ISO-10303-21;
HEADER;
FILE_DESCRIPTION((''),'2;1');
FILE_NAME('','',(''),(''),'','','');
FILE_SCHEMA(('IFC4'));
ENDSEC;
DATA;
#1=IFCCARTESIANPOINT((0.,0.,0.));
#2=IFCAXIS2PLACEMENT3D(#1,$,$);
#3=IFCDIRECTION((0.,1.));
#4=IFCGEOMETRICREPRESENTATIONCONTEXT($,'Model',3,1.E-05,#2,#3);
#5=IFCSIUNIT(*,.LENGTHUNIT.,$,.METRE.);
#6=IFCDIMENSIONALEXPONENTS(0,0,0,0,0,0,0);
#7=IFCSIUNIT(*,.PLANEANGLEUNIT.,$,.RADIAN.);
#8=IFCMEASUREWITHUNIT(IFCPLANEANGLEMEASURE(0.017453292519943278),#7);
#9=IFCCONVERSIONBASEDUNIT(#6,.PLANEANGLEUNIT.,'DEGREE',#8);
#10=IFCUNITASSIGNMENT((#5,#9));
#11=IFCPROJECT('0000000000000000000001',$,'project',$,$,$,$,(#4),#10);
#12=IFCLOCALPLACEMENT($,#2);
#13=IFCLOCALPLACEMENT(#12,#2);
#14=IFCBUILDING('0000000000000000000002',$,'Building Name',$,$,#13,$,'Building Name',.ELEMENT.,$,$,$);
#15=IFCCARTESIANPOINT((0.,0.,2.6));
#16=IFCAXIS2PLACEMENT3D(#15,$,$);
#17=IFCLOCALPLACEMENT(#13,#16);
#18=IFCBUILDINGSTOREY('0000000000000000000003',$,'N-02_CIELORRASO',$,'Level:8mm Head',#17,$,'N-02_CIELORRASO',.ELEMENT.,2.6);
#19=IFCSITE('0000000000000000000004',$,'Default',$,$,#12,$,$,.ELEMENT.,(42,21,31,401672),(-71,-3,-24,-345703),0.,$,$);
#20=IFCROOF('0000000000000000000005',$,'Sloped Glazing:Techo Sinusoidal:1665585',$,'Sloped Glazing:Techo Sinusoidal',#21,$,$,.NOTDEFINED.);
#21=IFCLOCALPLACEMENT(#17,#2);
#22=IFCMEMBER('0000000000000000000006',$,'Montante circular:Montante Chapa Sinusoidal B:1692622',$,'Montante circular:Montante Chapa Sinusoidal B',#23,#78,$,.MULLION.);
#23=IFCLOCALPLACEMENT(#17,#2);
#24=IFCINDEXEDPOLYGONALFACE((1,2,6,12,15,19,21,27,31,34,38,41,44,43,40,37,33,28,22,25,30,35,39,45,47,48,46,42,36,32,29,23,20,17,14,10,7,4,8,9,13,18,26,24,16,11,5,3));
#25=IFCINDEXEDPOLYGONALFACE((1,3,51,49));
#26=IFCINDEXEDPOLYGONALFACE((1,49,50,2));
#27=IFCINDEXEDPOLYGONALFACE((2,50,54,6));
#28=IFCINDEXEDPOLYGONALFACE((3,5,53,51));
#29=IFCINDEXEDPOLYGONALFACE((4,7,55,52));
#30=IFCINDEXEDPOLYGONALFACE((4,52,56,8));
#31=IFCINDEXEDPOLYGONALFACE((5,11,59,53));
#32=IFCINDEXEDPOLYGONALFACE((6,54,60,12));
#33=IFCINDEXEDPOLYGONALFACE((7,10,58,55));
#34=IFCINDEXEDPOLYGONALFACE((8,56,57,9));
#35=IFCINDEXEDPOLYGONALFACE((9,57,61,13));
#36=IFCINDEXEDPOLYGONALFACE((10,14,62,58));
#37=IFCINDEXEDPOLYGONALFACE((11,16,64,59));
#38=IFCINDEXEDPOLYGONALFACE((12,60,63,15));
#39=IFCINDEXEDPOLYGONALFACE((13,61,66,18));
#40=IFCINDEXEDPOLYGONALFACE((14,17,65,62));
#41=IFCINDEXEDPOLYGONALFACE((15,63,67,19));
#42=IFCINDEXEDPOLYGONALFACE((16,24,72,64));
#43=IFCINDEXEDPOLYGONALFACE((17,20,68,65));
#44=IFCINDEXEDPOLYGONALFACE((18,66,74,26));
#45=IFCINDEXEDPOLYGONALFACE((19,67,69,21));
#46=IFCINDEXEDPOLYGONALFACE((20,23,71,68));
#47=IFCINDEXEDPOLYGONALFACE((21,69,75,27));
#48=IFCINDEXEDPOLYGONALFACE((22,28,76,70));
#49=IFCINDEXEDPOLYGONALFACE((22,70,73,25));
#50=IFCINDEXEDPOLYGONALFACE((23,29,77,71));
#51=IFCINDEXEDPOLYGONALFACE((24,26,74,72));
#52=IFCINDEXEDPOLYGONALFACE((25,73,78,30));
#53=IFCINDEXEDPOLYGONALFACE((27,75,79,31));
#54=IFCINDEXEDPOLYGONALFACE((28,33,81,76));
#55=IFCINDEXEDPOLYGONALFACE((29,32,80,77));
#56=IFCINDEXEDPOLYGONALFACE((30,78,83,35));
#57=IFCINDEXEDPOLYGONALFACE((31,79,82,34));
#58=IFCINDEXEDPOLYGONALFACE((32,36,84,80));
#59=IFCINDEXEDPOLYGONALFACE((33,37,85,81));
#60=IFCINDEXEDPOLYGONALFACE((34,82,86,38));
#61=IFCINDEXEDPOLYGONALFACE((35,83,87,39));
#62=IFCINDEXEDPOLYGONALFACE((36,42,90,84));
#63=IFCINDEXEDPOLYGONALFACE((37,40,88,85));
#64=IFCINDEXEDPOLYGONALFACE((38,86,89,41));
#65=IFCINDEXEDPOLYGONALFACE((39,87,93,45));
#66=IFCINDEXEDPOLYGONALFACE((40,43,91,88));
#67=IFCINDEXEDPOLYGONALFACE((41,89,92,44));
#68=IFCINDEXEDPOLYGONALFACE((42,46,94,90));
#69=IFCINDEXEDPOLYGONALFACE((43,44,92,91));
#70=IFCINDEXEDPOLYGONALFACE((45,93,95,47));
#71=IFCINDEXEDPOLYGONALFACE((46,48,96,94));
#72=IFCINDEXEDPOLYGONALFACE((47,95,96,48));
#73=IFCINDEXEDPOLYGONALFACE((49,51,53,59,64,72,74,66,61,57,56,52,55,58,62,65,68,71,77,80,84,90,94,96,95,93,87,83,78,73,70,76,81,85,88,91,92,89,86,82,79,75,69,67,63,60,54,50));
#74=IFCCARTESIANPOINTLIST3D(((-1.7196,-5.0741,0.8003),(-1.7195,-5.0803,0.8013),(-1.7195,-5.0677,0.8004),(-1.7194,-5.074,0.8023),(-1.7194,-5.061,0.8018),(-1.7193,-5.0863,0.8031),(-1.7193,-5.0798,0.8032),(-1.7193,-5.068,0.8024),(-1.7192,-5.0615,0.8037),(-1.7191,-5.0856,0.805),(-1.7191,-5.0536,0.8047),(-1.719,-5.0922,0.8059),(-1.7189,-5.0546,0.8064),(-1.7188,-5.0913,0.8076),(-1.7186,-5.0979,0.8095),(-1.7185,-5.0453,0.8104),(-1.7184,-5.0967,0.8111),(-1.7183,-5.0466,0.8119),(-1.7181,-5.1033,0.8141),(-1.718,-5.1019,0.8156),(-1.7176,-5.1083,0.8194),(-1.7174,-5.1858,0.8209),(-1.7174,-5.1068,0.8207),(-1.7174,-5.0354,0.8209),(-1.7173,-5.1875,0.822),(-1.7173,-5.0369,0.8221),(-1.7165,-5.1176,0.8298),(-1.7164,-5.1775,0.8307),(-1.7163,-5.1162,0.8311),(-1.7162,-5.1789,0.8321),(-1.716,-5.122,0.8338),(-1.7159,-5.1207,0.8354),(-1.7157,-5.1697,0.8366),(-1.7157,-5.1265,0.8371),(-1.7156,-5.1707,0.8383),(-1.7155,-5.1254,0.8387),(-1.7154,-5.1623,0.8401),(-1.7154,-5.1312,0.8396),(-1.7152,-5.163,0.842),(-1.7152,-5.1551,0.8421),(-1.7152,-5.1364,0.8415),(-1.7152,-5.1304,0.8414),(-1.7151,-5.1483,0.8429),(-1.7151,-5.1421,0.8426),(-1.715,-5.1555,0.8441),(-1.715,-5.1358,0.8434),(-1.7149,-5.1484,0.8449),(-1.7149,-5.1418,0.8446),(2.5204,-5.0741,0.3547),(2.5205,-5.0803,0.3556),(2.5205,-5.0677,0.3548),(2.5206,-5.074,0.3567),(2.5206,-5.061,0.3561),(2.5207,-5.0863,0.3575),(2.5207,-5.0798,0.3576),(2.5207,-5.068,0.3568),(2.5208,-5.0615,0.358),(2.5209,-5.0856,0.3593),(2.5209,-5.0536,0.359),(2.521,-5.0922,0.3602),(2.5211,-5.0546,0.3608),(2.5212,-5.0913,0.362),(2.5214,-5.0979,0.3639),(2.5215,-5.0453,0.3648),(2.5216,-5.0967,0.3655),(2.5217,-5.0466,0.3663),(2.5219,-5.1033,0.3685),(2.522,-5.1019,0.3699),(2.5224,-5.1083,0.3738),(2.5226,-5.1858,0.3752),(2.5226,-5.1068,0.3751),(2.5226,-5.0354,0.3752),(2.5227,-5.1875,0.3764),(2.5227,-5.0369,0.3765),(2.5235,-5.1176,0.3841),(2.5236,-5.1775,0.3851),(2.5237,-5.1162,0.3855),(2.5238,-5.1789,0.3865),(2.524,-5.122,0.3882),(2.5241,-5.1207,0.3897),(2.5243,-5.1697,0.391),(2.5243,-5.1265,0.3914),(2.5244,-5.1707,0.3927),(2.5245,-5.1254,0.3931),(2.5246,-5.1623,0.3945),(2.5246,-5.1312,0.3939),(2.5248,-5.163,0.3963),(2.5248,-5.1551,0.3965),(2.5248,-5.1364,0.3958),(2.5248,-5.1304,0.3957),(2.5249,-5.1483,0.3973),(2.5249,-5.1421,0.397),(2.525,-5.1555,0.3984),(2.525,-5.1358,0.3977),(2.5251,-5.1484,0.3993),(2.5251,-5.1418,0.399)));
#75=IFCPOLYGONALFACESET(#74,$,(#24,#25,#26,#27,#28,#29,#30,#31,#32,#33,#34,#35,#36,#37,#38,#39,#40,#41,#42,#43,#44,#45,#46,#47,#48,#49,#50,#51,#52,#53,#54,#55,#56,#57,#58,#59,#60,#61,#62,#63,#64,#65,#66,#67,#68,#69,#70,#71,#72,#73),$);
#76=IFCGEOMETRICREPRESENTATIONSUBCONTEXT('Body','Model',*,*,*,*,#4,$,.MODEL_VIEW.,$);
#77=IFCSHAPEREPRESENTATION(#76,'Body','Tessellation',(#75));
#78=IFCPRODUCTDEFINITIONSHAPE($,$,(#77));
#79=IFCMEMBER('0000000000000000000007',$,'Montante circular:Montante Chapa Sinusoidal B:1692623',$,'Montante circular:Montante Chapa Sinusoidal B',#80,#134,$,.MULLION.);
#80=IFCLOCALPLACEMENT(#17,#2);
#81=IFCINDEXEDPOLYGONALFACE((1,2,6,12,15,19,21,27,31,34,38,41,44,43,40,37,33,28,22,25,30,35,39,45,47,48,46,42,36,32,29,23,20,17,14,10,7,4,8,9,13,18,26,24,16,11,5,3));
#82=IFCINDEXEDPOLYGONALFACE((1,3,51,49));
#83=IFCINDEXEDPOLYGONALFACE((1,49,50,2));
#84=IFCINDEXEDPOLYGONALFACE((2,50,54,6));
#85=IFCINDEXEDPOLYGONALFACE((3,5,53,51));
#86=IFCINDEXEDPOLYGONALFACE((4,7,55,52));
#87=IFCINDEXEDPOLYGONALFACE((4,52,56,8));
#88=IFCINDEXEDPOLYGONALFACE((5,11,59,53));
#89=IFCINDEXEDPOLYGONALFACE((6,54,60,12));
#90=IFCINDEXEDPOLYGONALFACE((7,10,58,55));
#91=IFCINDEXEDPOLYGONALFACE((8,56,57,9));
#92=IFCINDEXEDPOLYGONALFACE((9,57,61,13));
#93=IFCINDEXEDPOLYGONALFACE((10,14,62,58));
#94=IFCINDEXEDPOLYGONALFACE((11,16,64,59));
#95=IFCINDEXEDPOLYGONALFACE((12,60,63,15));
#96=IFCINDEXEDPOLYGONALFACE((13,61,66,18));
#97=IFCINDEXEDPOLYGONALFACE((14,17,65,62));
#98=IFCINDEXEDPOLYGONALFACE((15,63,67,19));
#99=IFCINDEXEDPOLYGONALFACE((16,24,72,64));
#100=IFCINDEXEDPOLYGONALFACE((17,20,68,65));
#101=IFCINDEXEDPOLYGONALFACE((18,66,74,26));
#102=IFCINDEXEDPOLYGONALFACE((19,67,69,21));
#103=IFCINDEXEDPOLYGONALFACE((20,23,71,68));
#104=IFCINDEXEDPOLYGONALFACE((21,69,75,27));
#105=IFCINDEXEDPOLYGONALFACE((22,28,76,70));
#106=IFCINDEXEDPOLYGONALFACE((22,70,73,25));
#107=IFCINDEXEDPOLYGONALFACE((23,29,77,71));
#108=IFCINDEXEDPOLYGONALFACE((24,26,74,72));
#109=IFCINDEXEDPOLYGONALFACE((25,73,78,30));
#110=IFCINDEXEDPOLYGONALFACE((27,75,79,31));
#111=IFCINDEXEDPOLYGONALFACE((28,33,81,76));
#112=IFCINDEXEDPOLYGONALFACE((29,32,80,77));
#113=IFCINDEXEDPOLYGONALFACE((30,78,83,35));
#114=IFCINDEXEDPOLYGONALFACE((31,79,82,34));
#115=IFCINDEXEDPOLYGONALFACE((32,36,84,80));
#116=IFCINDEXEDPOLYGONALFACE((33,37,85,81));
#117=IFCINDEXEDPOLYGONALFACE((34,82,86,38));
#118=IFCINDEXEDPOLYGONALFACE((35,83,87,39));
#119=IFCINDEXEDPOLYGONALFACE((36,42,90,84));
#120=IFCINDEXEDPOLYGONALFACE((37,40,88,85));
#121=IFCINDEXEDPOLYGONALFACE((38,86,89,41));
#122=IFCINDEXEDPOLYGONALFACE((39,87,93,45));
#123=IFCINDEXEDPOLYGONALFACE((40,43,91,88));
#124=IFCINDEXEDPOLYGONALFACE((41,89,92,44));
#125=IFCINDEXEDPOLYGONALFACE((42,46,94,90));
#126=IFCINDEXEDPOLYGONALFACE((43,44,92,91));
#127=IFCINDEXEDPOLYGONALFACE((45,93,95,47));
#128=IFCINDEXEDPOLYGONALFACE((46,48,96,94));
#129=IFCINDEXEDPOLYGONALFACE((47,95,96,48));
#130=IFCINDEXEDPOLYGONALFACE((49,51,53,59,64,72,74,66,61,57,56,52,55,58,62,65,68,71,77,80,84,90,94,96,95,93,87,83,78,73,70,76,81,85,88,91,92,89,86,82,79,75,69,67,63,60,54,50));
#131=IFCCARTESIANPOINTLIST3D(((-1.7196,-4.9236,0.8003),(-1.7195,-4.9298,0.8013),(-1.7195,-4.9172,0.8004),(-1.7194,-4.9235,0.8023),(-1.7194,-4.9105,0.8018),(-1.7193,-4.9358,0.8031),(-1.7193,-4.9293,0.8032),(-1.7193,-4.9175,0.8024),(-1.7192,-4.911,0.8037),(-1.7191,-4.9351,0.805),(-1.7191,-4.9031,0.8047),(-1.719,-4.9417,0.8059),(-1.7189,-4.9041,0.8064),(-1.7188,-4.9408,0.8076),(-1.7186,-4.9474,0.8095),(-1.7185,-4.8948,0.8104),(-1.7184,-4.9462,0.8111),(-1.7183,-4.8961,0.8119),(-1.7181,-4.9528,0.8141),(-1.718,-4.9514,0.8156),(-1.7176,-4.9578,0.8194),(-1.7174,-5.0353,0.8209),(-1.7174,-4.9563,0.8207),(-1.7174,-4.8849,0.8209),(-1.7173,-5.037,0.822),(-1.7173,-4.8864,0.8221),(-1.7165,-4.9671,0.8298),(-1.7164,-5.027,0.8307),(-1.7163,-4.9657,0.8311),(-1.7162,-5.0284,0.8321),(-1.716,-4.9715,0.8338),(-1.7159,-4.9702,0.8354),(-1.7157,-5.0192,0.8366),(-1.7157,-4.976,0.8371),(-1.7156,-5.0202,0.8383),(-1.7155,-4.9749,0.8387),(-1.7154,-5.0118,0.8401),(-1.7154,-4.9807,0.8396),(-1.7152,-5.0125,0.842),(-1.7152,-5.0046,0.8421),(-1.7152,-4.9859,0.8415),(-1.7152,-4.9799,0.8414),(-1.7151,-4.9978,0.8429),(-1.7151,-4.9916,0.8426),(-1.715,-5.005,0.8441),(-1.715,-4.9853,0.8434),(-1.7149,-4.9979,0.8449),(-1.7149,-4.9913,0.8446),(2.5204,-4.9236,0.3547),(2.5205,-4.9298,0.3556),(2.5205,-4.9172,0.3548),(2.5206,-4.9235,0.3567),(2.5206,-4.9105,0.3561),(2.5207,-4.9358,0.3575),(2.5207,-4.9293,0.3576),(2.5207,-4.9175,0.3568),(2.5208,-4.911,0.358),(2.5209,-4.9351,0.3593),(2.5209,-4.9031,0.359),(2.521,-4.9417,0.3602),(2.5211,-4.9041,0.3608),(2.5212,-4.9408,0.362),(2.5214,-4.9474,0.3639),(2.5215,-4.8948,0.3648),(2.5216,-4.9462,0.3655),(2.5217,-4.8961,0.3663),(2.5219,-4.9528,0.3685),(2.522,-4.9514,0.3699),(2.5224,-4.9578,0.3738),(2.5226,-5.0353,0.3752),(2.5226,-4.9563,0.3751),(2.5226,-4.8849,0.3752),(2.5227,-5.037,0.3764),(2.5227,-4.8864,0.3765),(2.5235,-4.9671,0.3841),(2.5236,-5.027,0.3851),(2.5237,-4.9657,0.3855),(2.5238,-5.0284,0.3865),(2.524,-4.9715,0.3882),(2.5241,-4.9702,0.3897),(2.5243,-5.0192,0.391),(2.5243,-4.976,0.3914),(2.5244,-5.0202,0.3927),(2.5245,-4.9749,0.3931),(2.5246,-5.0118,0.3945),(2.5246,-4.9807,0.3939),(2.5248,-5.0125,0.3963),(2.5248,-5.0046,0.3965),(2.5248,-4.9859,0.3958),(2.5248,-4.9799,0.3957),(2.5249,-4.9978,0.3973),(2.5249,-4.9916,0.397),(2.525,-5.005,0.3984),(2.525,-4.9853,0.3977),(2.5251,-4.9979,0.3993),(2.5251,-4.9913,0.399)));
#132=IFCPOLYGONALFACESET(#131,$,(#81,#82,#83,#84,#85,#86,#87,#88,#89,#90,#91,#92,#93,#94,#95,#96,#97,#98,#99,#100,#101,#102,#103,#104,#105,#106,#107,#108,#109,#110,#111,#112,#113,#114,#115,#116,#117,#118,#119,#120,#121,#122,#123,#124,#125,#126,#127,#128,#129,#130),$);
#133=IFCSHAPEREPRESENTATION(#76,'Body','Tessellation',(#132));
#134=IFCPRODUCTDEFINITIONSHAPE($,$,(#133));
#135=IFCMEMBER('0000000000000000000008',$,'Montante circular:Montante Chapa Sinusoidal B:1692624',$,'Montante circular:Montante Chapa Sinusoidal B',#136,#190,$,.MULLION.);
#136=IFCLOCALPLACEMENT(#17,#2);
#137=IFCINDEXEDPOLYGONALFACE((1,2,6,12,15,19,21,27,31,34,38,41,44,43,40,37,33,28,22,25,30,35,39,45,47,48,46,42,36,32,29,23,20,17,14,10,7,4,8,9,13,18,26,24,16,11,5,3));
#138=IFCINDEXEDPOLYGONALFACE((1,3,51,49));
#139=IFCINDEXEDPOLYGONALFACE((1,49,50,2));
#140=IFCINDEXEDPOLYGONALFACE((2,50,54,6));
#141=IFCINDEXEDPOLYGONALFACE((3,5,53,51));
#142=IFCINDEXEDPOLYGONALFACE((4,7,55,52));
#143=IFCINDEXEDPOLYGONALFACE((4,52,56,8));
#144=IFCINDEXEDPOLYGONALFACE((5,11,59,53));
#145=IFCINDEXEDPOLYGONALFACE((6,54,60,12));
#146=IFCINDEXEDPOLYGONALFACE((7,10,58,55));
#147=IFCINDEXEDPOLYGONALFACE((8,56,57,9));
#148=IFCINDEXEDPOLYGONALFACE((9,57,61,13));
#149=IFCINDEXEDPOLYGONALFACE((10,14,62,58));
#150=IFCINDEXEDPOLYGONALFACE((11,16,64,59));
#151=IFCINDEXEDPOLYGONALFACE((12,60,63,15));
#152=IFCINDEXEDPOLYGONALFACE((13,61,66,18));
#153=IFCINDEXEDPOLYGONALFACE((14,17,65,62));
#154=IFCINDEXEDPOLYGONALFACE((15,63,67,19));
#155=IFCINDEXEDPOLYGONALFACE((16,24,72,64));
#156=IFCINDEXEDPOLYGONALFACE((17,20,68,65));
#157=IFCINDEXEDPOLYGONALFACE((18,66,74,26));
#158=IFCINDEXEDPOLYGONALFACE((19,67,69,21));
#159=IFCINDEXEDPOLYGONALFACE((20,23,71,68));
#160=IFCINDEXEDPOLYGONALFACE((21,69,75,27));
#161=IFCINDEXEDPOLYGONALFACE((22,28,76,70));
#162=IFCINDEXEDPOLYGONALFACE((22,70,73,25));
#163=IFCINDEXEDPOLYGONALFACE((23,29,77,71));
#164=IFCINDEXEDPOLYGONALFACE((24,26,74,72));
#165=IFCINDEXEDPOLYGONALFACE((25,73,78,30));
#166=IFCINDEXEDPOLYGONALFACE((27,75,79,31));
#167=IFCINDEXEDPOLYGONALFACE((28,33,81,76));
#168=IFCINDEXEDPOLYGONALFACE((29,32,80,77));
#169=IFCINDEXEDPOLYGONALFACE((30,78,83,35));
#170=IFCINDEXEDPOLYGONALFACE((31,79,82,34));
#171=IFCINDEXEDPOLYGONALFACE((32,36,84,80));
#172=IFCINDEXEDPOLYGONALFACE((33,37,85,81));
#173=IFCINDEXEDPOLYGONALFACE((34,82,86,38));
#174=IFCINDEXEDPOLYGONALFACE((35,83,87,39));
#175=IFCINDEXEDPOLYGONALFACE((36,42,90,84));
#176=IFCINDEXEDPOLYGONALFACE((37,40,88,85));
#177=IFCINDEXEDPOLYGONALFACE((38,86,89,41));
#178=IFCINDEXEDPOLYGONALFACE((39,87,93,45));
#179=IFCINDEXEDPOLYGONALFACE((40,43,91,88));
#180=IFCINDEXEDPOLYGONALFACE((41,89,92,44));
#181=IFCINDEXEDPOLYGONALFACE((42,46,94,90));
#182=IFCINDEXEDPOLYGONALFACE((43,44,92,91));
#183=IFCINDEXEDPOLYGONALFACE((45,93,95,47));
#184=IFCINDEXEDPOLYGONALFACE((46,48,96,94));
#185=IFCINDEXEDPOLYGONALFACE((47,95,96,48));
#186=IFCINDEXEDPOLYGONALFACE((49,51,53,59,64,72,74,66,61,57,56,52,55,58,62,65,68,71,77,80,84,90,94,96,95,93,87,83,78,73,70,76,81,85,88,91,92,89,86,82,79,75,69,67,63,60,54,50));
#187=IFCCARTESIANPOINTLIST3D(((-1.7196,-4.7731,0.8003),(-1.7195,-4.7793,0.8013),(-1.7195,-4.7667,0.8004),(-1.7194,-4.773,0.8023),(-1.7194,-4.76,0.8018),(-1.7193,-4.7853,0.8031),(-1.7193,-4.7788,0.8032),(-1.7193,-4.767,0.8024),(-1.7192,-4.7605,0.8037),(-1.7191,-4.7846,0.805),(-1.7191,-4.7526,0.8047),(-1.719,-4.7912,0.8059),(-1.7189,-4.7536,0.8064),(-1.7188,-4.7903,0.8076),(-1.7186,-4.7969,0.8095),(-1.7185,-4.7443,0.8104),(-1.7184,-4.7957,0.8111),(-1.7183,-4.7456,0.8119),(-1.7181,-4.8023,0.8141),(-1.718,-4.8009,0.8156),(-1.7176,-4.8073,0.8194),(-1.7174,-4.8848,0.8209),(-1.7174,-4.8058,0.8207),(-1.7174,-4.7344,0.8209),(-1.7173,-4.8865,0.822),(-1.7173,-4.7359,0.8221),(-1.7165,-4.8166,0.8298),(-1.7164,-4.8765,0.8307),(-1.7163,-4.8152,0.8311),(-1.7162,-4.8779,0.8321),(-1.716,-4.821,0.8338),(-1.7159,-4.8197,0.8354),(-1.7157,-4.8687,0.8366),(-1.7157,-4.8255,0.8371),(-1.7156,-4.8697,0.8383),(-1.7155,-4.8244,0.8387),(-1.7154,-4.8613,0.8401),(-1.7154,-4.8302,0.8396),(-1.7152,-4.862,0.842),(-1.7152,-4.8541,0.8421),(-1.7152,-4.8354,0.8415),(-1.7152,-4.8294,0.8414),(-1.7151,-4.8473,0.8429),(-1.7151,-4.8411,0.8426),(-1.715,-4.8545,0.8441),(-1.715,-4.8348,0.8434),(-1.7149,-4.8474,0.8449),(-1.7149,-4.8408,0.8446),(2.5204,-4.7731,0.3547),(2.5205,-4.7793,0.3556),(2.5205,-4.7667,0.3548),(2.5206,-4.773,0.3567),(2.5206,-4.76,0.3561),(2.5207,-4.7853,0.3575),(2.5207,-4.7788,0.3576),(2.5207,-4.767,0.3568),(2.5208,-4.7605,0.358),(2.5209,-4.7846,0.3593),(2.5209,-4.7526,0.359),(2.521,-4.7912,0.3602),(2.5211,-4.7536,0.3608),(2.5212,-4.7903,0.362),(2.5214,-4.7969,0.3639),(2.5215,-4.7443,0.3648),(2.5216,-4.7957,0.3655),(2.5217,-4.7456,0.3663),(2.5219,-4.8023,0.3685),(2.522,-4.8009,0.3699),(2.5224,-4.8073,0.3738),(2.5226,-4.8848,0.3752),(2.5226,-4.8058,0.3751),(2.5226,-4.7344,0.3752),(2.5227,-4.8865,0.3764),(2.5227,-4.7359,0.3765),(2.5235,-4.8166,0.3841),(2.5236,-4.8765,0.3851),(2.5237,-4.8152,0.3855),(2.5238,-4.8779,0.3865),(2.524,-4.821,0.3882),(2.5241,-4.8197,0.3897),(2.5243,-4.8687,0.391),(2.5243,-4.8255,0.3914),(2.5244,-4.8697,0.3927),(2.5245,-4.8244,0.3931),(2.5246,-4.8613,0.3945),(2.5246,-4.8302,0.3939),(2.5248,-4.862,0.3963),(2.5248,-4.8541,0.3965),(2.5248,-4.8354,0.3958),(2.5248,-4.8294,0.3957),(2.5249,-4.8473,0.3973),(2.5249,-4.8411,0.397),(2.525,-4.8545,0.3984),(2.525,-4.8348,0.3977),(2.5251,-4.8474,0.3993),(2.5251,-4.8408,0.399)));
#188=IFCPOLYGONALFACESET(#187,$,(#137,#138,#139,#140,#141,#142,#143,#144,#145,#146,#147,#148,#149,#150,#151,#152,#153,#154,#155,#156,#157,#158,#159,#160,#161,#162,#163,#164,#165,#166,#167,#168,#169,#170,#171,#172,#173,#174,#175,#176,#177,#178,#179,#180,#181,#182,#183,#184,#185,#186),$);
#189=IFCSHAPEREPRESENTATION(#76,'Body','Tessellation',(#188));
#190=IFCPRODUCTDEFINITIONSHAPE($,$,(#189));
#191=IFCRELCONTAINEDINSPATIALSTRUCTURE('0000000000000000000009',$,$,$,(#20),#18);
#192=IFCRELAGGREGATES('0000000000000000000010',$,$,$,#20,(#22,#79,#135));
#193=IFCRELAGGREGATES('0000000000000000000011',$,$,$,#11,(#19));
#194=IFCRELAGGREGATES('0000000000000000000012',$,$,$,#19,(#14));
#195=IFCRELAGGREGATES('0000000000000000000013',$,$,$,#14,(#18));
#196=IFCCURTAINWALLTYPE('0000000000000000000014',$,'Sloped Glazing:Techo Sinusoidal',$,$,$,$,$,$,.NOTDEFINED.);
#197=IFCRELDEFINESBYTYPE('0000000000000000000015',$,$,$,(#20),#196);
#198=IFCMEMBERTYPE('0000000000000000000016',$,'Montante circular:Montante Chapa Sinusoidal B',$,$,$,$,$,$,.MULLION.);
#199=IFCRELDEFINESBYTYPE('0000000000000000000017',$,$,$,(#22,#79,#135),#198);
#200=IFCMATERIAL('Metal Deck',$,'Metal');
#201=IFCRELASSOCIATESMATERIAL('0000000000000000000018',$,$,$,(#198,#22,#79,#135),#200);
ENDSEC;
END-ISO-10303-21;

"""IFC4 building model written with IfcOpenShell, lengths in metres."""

from ifc_helpers import new_model, entity, si_unit, converted_unit, direction, frame, origin, place, context, subcontext, project, spatial, indexed_curve, outline, extrude, source, transform, mapped, material, type_object, type_shapes, element, aggregate, save


model = new_model("IFC4")

# Units and contexts
model_context = context("Model", 3, precision=1e-05, world=origin(), true_north=direction((0.0, 1.0)))
body_context = subcontext(model_context, "Body", "Model", "MODEL_VIEW")
ifc_project = project(units=[si_unit("LENGTHUNIT", "METRE"), converted_unit("PLANEANGLEUNIT", "DEGREE", entity("IfcPlaneAngleMeasure", 0.017453292519943278), si_unit("PLANEANGLEUNIT", "RADIAN"), dimensions=[0, 0, 0, 0, 0, 0, 0])], contexts=[model_context])

# Site, building, storey
site_placement = place(None, origin())
site = spatial("IfcSite", under=ifc_project, at=site_placement, Name="Default", CompositionType="ELEMENT", RefLatitude=(42, 21, 31, 401672), RefLongitude=(-71, -3, -24, -345703), RefElevation=0.0)
building_placement = place(site_placement, origin())
building = spatial("IfcBuilding", under=site, at=building_placement, Name="Building Name", LongName="Building Name", CompositionType="ELEMENT")
storey_placement = place(building_placement, frame((0.0, 0.0, 2.6)))
storey = spatial("IfcBuildingStorey", under=building, at=storey_placement, Name="N-02_CIELORRASO", ObjectType="Level:8mm Head", LongName="N-02_CIELORRASO", CompositionType="ELEMENT", Elevation=2.6)

# Roof, members
curtain_wall_type = type_object("IfcCurtainWallType", Name="Sloped Glazing:Techo Sinusoidal", PredefinedType="NOTDEFINED")
roof_1_placement = place(storey_placement, frame((0.0, 0.0, -2.6)))
roof_1 = element("IfcRoof", 1, at=roof_1_placement, inside=storey, type_object=curtain_wall_type, Name="Sloped Glazing:Techo Sinusoidal:1665585", ObjectType="Sloped Glazing:Techo Sinusoidal", PredefinedType="NOTDEFINED")
ifc_material = material(Name="Metal Deck", Category="Metal")
member_type_1 = type_object("IfcMemberType", Name="Montante circular:Montante Chapa Sinusoidal B", PredefinedType="MULLION", material=ifc_material)
shared_shape_1 = source(origin(), body_context, "Body", "SweptSolid", [
    extrude(outline(indexed_curve([(0.0595, -0.0443), (0.0615, -0.0443), (0.0603, -0.031), (0.0572, -0.0213), (0.053, -0.0138), (0.0481, -0.0078), (0.0427, -0.003), (0.0372, 0.0005), (0.0315, 0.0029), (0.0259, 0.0044), (0.0203, 0.0051), (0.0146, 0.005), (0.0084, 0.0041), (-0.0053, 0.0009), (-0.0123, -0.0005), (-0.0191, -0.0012), (-0.0256, -0.001), (-0.0317, 0.0001), (-0.0375, 0.0019), (-0.0428, 0.0046), (-0.0477, 0.0081), (-0.0522, 0.0128), (-0.0563, 0.0191), (-0.0597, 0.0282), (-0.0617, 0.0421), (-0.0637, 0.042), (-0.0616, 0.0277), (-0.0581, 0.0182), (-0.0537, 0.0116), (-0.049, 0.0066), (-0.0438, 0.0028), (-0.0382, 0.0001), (-0.0322, -0.0019), (-0.0258, -0.003), (-0.019, -0.0032), (-0.012, -0.0025), (-0.0048, -0.0011), (0.0088, 0.0021), (0.0147, 0.003), (0.0202, 0.0031), (0.0255, 0.0024), (0.0309, 0.001), (0.0362, -0.0013), (0.0415, -0.0046), (0.0466, -0.0092), (0.0513, -0.0149), (0.0554, -0.0221), (0.0584, -0.0314), (0.0595, -0.0443)], self_intersect=False)), frame((-0.007, 0.0228, -4.2634), z_axis=(0.0, 0.0, 1.0), x_axis=(-0.819152, -0.573576, 0.0)), (0.0, 0.0, 1.0), 4.2634),
])
type_shapes(member_type_1, [shared_shape_1])
member_1_placement = place(roof_1_placement, frame((-1.7148, -5.1046, 3.4456), z_axis=(-0.994522, 0.0, 0.104528), x_axis=(0.0, 1.0, 0.0)))
member_1 = element("IfcMember", 2, at=member_1_placement, type_object=member_type_1, material=ifc_material, Name="Montante circular:Montante Chapa Sinusoidal B:1692622", ObjectType="Montante circular:Montante Chapa Sinusoidal B", PredefinedType="MULLION", context=body_context, shape_type="MappedRepresentation", body=[
    mapped(shared_shape_1, transform((0.0, 0.0, 0.0), scale=1.0)),
])
member_2_placement = place(roof_1_placement, frame((-1.7148, -4.9541, 3.4456), z_axis=(-0.994522, 0.0, 0.104528), x_axis=(0.0, 1.0, 0.0)))
member_2 = element("IfcMember", 3, at=member_2_placement, type_object=member_type_1, material=ifc_material, Name="Montante circular:Montante Chapa Sinusoidal B:1692623", ObjectType="Montante circular:Montante Chapa Sinusoidal B", PredefinedType="MULLION", context=body_context, shape_type="MappedRepresentation", body=[
    mapped(shared_shape_1, transform((0.0, 0.0, 0.0), scale=1.0)),
])
member_3_placement = place(roof_1_placement, frame((-1.7148, -4.8036, 3.4456), z_axis=(-0.994522, 0.0, 0.104528), x_axis=(0.0, 1.0, 0.0)))
member_3 = element("IfcMember", 4, at=member_3_placement, type_object=member_type_1, material=ifc_material, Name="Montante circular:Montante Chapa Sinusoidal B:1692624", ObjectType="Montante circular:Montante Chapa Sinusoidal B", PredefinedType="MULLION", context=body_context, shape_type="MappedRepresentation", body=[
    mapped(shared_shape_1, transform((0.0, 0.0, 0.0), scale=1.0)),
])
aggregate(roof_1, [member_1, member_2, member_3])

save(model, "model.ifc")
